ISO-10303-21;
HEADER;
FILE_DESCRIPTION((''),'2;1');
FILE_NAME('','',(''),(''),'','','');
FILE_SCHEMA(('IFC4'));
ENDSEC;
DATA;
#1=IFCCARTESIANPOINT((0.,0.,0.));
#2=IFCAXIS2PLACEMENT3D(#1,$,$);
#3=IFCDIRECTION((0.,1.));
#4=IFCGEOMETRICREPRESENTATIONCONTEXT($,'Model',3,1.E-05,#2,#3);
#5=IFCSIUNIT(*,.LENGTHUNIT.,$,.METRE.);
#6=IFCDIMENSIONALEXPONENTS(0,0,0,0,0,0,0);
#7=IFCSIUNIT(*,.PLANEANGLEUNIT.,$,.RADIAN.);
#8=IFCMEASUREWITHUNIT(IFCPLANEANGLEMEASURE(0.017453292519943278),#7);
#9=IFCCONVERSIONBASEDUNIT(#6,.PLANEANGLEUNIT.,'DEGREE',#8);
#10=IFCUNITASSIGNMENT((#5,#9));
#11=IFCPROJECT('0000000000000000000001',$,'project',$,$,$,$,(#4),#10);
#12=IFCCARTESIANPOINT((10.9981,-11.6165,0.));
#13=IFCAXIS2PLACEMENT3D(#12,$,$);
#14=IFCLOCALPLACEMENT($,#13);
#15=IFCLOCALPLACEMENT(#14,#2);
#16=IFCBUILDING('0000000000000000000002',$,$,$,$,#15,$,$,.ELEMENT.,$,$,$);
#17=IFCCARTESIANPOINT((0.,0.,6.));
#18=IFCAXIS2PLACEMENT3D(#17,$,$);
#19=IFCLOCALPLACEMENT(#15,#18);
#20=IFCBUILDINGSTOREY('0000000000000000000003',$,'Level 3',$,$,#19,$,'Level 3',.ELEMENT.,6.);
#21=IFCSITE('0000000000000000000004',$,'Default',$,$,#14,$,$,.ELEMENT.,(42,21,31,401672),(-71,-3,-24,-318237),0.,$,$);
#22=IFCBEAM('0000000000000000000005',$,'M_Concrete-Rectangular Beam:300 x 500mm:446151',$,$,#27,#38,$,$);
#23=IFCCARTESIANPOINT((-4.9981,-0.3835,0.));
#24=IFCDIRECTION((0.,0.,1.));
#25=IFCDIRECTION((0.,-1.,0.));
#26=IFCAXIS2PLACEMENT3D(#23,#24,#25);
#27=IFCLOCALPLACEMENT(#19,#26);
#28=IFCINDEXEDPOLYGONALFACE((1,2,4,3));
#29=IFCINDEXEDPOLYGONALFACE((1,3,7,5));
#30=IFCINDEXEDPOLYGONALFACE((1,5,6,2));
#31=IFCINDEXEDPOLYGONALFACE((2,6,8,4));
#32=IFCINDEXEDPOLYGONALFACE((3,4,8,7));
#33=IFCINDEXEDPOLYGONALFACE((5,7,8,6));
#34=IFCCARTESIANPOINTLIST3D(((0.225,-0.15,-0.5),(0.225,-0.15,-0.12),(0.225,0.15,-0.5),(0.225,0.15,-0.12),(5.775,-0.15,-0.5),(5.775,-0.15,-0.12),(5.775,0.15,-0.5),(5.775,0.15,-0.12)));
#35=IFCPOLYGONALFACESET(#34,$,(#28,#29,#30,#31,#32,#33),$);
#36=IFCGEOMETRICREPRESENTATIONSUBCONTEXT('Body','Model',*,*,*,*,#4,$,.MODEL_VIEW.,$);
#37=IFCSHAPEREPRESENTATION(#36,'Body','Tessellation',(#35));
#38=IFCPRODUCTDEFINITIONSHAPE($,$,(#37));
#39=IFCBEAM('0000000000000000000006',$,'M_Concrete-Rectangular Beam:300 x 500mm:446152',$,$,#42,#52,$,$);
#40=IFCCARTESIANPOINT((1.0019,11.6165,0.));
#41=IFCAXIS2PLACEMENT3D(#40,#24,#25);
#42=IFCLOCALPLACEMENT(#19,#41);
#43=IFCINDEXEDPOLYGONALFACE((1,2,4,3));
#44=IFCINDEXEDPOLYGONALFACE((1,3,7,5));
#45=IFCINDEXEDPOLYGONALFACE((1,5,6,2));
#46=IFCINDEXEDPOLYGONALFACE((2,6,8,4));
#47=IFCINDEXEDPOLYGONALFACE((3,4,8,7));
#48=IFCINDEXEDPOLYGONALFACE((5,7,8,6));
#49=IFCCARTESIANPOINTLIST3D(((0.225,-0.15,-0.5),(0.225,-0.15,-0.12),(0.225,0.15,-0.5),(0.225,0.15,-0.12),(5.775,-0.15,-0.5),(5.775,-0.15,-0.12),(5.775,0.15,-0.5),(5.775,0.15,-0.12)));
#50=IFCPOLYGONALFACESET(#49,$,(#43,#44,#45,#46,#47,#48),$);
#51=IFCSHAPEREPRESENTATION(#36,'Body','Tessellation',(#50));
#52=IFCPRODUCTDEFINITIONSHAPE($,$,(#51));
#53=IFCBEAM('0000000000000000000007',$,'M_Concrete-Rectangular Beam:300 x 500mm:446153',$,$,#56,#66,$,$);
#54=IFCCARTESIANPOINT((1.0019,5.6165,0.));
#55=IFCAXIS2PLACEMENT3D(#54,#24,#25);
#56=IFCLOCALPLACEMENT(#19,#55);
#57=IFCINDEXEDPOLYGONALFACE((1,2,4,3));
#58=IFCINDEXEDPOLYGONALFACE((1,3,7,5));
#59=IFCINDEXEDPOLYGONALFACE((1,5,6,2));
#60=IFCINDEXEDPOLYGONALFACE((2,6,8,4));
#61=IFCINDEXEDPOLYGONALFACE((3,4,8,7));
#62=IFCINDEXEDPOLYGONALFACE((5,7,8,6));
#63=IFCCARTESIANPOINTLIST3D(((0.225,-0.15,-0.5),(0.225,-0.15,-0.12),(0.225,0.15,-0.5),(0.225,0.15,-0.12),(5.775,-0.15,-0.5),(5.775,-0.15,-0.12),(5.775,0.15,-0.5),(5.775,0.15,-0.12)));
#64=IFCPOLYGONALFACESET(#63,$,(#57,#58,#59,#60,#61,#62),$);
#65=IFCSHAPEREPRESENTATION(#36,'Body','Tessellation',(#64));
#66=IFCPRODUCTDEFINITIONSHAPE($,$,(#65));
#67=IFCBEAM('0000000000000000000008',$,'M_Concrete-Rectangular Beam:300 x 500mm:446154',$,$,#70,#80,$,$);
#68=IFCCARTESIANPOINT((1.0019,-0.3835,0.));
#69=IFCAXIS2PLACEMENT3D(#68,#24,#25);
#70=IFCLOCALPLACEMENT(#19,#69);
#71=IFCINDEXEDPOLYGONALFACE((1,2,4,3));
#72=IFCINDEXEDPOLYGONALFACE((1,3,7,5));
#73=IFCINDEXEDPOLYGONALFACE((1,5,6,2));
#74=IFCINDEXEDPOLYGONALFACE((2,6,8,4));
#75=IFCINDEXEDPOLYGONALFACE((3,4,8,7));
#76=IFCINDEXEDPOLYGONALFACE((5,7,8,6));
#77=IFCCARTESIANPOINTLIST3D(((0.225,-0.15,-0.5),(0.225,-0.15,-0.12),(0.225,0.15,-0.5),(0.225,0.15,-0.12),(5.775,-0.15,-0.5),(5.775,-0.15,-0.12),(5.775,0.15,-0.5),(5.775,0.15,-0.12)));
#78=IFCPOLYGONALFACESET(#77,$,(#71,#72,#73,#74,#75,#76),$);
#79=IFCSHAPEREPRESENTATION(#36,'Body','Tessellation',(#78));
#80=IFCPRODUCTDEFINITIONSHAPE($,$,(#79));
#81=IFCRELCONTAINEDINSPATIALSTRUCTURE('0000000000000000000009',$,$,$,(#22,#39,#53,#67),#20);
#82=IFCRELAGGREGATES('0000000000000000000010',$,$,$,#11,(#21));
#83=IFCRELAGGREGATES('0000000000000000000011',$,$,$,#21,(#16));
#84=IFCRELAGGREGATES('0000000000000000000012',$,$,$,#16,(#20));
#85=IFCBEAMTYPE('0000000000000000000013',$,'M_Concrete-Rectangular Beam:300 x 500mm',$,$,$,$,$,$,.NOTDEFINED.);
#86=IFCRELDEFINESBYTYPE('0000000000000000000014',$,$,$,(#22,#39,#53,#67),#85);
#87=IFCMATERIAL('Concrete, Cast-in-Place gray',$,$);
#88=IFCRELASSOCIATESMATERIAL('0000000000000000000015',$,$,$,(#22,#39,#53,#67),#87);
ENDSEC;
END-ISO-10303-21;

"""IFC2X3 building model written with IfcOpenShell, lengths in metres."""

from ifc_helpers import new_model, entity, si_unit, converted_unit, direction, frame, frame_2d, origin, place, context, subcontext, project, spatial, rectangle, extrude, material, type_object, element, save


model = new_model("IFC2X3")

# Units and contexts
model_context = context("Model", 3, precision=1e-05, world=origin(), true_north=direction((0.0, 1.0)))
body_context = subcontext(model_context, "Body", "Model", "MODEL_VIEW")
ifc_project = project(units=[si_unit("LENGTHUNIT", "METRE"), converted_unit("PLANEANGLEUNIT", "DEGREE", entity("IfcPlaneAngleMeasure", 0.017453292519943278), si_unit("PLANEANGLEUNIT", "RADIAN"), dimensions=[0, 0, 0, 0, 0, 0, 0])], contexts=[model_context])

# Site, building, storey
site_placement = place(None, frame((10.9981, -11.6165, 0.0)))
site = spatial("IfcSite", under=ifc_project, at=site_placement, Name="Default", CompositionType="ELEMENT", RefLatitude=(42, 21, 31, 401672), RefLongitude=(-71, -3, -24, -318237), RefElevation=0.0)
building_placement = place(site_placement, origin())
building = spatial("IfcBuilding", under=site, at=building_placement, CompositionType="ELEMENT")
storey_placement = place(building_placement, frame((0.0, 0.0, 6.0)))
storey = spatial("IfcBuildingStorey", under=building, at=storey_placement, Name="Level 3", LongName="Level 3", CompositionType="ELEMENT", Elevation=6.0)

# Shared definitions
ifc_material_1 = material(Name="Concrete, Cast-in-Place gray")

# Beams
beam_type = type_object("IfcBeamType", Name="M_Concrete-Rectangular Beam:300 x 500mm", PredefinedType="NOTDEFINED")
beam_1_placement = place(storey_placement, frame((-4.9981, -0.3835, 0.0), z_axis=(0.0, 0.0, 1.0), x_axis=(0.0, -1.0, 0.0)))
element("IfcBeam", 1, at=beam_1_placement, inside=storey, type_object=beam_type, material=ifc_material_1, Name="M_Concrete-Rectangular Beam:300 x 500mm:446151", context=body_context, shape_type="SweptSolid", body=[
    extrude(rectangle(XDim=0.38, YDim=0.3, at=frame_2d((0.0, 0.0), x_axis=(1.0, 0.0))), frame((0.225, 0.0, -0.31), z_axis=(1.0, 0.0, 0.0), x_axis=(0.0, 0.0, -1.0)), (0.0, 0.0, 1.0), 5.55),
])
beam_2_placement = place(storey_placement, frame((1.0019, 11.6165, 0.0), z_axis=(0.0, 0.0, 1.0), x_axis=(0.0, -1.0, 0.0)))
element("IfcBeam", 2, at=beam_2_placement, inside=storey, type_object=beam_type, material=ifc_material_1, Name="M_Concrete-Rectangular Beam:300 x 500mm:446152", context=body_context, shape_type="SweptSolid", body=[
    extrude(rectangle(XDim=0.38, YDim=0.3, at=frame_2d((0.0, 0.0), x_axis=(1.0, 0.0))), frame((0.225, 0.0, -0.31), z_axis=(1.0, 0.0, 0.0), x_axis=(0.0, 0.0, -1.0)), (0.0, 0.0, 1.0), 5.55),
])
beam_3_placement = place(storey_placement, frame((1.0019, 5.6165, 0.0), z_axis=(0.0, 0.0, 1.0), x_axis=(0.0, -1.0, 0.0)))
element("IfcBeam", 3, at=beam_3_placement, inside=storey, type_object=beam_type, material=ifc_material_1, Name="M_Concrete-Rectangular Beam:300 x 500mm:446153", context=body_context, shape_type="SweptSolid", body=[
    extrude(rectangle(XDim=0.38, YDim=0.3, at=frame_2d((0.0, 0.0), x_axis=(1.0, 0.0))), frame((0.225, 0.0, -0.31), z_axis=(1.0, 0.0, 0.0), x_axis=(0.0, 0.0, -1.0)), (0.0, 0.0, 1.0), 5.55),
])
beam_4_placement = place(storey_placement, frame((1.0019, -0.3835, 0.0), z_axis=(0.0, 0.0, 1.0), x_axis=(0.0, -1.0, 0.0)))
element("IfcBeam", 4, at=beam_4_placement, inside=storey, type_object=beam_type, material=ifc_material_1, Name="M_Concrete-Rectangular Beam:300 x 500mm:446154", context=body_context, shape_type="SweptSolid", body=[
    extrude(rectangle(XDim=0.38, YDim=0.3, at=frame_2d((0.0, 0.0), x_axis=(1.0, 0.0))), frame((0.225, 0.0, -0.31), z_axis=(1.0, 0.0, 0.0), x_axis=(0.0, 0.0, -1.0)), (0.0, 0.0, 1.0), 5.55),
])

save(model, "model.ifc")
